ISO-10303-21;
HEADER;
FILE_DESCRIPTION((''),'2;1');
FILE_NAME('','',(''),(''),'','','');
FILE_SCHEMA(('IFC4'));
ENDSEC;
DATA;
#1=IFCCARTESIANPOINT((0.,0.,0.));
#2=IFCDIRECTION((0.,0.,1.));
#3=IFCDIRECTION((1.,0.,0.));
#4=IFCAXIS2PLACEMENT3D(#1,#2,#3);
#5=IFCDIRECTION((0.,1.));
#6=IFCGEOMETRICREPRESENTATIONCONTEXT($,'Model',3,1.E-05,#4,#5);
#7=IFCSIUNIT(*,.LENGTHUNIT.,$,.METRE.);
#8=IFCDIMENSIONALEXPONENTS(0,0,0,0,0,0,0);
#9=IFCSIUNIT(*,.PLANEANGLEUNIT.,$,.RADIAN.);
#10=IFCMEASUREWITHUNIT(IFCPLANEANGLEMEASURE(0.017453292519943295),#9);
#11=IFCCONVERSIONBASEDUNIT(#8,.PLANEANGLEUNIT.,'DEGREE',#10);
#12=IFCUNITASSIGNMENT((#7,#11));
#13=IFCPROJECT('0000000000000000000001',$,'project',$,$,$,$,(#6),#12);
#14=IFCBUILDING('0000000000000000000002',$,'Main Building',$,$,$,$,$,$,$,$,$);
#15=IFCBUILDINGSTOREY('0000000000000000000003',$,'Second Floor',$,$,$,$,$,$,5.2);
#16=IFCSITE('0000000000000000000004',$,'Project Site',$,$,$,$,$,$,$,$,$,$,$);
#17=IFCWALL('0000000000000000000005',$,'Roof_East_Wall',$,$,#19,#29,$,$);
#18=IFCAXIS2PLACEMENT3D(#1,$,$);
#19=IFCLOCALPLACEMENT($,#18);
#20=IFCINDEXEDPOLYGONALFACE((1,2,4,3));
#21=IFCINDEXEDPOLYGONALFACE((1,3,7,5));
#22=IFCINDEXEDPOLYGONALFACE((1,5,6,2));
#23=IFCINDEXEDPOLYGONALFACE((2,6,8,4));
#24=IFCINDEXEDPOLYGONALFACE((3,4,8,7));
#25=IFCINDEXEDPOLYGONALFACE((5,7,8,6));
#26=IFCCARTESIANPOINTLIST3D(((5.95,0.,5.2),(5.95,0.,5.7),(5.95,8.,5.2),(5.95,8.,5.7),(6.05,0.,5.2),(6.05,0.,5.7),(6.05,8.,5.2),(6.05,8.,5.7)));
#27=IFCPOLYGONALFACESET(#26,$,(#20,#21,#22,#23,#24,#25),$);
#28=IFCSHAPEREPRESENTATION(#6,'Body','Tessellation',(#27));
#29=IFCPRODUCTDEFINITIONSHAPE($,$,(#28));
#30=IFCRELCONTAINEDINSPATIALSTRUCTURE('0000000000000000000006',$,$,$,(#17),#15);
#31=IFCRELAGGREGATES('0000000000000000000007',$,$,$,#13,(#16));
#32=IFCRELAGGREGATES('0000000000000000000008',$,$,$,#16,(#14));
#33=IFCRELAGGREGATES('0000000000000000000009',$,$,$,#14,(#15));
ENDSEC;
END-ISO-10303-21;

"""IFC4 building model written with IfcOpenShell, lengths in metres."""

from ifc_helpers import new_model, entity, si_unit, converted_unit, direction, frame, frame_2d, origin, origin_with_axes, place, context, project, spatial, rectangle, extrude, element, save


model = new_model("IFC4")

# Units and contexts
model_context = context("Model", 3, precision=1e-05, world=origin_with_axes(), true_north=direction((0.0, 1.0)))
ifc_project = project(units=[si_unit("LENGTHUNIT", "METRE"), converted_unit("PLANEANGLEUNIT", "DEGREE", entity("IfcPlaneAngleMeasure", 0.017453292519943295), si_unit("PLANEANGLEUNIT", "RADIAN"), dimensions=[0, 0, 0, 0, 0, 0, 0])], contexts=[model_context])

# Site, building, storey
site = spatial("IfcSite", under=ifc_project, Name="Project Site")
building = spatial("IfcBuilding", under=site, Name="Main Building")
storey = spatial("IfcBuildingStorey", under=building, Name="Second Floor", Elevation=5.2)

# Wall
for number, where, z_axis, x_axis, name in (
    (1, (6.0, 0.0, 5.2), (0.0, 0.0, 1.0), (0.0, 1.0, 0.0), "Roof_East_Wall"),
):
    element("IfcWall", number, at=place(None, frame(where, z_axis=z_axis, x_axis=x_axis)), inside=storey, Name=name, context=model_context, shape_type="SweptSolid", body=[
        extrude(rectangle(XDim=8.0, YDim=0.1, at=frame_2d((4.0, 0.0))), origin(), (0.0, 0.0, 1.0), 0.5),
    ])

save(model, "model.ifc")
